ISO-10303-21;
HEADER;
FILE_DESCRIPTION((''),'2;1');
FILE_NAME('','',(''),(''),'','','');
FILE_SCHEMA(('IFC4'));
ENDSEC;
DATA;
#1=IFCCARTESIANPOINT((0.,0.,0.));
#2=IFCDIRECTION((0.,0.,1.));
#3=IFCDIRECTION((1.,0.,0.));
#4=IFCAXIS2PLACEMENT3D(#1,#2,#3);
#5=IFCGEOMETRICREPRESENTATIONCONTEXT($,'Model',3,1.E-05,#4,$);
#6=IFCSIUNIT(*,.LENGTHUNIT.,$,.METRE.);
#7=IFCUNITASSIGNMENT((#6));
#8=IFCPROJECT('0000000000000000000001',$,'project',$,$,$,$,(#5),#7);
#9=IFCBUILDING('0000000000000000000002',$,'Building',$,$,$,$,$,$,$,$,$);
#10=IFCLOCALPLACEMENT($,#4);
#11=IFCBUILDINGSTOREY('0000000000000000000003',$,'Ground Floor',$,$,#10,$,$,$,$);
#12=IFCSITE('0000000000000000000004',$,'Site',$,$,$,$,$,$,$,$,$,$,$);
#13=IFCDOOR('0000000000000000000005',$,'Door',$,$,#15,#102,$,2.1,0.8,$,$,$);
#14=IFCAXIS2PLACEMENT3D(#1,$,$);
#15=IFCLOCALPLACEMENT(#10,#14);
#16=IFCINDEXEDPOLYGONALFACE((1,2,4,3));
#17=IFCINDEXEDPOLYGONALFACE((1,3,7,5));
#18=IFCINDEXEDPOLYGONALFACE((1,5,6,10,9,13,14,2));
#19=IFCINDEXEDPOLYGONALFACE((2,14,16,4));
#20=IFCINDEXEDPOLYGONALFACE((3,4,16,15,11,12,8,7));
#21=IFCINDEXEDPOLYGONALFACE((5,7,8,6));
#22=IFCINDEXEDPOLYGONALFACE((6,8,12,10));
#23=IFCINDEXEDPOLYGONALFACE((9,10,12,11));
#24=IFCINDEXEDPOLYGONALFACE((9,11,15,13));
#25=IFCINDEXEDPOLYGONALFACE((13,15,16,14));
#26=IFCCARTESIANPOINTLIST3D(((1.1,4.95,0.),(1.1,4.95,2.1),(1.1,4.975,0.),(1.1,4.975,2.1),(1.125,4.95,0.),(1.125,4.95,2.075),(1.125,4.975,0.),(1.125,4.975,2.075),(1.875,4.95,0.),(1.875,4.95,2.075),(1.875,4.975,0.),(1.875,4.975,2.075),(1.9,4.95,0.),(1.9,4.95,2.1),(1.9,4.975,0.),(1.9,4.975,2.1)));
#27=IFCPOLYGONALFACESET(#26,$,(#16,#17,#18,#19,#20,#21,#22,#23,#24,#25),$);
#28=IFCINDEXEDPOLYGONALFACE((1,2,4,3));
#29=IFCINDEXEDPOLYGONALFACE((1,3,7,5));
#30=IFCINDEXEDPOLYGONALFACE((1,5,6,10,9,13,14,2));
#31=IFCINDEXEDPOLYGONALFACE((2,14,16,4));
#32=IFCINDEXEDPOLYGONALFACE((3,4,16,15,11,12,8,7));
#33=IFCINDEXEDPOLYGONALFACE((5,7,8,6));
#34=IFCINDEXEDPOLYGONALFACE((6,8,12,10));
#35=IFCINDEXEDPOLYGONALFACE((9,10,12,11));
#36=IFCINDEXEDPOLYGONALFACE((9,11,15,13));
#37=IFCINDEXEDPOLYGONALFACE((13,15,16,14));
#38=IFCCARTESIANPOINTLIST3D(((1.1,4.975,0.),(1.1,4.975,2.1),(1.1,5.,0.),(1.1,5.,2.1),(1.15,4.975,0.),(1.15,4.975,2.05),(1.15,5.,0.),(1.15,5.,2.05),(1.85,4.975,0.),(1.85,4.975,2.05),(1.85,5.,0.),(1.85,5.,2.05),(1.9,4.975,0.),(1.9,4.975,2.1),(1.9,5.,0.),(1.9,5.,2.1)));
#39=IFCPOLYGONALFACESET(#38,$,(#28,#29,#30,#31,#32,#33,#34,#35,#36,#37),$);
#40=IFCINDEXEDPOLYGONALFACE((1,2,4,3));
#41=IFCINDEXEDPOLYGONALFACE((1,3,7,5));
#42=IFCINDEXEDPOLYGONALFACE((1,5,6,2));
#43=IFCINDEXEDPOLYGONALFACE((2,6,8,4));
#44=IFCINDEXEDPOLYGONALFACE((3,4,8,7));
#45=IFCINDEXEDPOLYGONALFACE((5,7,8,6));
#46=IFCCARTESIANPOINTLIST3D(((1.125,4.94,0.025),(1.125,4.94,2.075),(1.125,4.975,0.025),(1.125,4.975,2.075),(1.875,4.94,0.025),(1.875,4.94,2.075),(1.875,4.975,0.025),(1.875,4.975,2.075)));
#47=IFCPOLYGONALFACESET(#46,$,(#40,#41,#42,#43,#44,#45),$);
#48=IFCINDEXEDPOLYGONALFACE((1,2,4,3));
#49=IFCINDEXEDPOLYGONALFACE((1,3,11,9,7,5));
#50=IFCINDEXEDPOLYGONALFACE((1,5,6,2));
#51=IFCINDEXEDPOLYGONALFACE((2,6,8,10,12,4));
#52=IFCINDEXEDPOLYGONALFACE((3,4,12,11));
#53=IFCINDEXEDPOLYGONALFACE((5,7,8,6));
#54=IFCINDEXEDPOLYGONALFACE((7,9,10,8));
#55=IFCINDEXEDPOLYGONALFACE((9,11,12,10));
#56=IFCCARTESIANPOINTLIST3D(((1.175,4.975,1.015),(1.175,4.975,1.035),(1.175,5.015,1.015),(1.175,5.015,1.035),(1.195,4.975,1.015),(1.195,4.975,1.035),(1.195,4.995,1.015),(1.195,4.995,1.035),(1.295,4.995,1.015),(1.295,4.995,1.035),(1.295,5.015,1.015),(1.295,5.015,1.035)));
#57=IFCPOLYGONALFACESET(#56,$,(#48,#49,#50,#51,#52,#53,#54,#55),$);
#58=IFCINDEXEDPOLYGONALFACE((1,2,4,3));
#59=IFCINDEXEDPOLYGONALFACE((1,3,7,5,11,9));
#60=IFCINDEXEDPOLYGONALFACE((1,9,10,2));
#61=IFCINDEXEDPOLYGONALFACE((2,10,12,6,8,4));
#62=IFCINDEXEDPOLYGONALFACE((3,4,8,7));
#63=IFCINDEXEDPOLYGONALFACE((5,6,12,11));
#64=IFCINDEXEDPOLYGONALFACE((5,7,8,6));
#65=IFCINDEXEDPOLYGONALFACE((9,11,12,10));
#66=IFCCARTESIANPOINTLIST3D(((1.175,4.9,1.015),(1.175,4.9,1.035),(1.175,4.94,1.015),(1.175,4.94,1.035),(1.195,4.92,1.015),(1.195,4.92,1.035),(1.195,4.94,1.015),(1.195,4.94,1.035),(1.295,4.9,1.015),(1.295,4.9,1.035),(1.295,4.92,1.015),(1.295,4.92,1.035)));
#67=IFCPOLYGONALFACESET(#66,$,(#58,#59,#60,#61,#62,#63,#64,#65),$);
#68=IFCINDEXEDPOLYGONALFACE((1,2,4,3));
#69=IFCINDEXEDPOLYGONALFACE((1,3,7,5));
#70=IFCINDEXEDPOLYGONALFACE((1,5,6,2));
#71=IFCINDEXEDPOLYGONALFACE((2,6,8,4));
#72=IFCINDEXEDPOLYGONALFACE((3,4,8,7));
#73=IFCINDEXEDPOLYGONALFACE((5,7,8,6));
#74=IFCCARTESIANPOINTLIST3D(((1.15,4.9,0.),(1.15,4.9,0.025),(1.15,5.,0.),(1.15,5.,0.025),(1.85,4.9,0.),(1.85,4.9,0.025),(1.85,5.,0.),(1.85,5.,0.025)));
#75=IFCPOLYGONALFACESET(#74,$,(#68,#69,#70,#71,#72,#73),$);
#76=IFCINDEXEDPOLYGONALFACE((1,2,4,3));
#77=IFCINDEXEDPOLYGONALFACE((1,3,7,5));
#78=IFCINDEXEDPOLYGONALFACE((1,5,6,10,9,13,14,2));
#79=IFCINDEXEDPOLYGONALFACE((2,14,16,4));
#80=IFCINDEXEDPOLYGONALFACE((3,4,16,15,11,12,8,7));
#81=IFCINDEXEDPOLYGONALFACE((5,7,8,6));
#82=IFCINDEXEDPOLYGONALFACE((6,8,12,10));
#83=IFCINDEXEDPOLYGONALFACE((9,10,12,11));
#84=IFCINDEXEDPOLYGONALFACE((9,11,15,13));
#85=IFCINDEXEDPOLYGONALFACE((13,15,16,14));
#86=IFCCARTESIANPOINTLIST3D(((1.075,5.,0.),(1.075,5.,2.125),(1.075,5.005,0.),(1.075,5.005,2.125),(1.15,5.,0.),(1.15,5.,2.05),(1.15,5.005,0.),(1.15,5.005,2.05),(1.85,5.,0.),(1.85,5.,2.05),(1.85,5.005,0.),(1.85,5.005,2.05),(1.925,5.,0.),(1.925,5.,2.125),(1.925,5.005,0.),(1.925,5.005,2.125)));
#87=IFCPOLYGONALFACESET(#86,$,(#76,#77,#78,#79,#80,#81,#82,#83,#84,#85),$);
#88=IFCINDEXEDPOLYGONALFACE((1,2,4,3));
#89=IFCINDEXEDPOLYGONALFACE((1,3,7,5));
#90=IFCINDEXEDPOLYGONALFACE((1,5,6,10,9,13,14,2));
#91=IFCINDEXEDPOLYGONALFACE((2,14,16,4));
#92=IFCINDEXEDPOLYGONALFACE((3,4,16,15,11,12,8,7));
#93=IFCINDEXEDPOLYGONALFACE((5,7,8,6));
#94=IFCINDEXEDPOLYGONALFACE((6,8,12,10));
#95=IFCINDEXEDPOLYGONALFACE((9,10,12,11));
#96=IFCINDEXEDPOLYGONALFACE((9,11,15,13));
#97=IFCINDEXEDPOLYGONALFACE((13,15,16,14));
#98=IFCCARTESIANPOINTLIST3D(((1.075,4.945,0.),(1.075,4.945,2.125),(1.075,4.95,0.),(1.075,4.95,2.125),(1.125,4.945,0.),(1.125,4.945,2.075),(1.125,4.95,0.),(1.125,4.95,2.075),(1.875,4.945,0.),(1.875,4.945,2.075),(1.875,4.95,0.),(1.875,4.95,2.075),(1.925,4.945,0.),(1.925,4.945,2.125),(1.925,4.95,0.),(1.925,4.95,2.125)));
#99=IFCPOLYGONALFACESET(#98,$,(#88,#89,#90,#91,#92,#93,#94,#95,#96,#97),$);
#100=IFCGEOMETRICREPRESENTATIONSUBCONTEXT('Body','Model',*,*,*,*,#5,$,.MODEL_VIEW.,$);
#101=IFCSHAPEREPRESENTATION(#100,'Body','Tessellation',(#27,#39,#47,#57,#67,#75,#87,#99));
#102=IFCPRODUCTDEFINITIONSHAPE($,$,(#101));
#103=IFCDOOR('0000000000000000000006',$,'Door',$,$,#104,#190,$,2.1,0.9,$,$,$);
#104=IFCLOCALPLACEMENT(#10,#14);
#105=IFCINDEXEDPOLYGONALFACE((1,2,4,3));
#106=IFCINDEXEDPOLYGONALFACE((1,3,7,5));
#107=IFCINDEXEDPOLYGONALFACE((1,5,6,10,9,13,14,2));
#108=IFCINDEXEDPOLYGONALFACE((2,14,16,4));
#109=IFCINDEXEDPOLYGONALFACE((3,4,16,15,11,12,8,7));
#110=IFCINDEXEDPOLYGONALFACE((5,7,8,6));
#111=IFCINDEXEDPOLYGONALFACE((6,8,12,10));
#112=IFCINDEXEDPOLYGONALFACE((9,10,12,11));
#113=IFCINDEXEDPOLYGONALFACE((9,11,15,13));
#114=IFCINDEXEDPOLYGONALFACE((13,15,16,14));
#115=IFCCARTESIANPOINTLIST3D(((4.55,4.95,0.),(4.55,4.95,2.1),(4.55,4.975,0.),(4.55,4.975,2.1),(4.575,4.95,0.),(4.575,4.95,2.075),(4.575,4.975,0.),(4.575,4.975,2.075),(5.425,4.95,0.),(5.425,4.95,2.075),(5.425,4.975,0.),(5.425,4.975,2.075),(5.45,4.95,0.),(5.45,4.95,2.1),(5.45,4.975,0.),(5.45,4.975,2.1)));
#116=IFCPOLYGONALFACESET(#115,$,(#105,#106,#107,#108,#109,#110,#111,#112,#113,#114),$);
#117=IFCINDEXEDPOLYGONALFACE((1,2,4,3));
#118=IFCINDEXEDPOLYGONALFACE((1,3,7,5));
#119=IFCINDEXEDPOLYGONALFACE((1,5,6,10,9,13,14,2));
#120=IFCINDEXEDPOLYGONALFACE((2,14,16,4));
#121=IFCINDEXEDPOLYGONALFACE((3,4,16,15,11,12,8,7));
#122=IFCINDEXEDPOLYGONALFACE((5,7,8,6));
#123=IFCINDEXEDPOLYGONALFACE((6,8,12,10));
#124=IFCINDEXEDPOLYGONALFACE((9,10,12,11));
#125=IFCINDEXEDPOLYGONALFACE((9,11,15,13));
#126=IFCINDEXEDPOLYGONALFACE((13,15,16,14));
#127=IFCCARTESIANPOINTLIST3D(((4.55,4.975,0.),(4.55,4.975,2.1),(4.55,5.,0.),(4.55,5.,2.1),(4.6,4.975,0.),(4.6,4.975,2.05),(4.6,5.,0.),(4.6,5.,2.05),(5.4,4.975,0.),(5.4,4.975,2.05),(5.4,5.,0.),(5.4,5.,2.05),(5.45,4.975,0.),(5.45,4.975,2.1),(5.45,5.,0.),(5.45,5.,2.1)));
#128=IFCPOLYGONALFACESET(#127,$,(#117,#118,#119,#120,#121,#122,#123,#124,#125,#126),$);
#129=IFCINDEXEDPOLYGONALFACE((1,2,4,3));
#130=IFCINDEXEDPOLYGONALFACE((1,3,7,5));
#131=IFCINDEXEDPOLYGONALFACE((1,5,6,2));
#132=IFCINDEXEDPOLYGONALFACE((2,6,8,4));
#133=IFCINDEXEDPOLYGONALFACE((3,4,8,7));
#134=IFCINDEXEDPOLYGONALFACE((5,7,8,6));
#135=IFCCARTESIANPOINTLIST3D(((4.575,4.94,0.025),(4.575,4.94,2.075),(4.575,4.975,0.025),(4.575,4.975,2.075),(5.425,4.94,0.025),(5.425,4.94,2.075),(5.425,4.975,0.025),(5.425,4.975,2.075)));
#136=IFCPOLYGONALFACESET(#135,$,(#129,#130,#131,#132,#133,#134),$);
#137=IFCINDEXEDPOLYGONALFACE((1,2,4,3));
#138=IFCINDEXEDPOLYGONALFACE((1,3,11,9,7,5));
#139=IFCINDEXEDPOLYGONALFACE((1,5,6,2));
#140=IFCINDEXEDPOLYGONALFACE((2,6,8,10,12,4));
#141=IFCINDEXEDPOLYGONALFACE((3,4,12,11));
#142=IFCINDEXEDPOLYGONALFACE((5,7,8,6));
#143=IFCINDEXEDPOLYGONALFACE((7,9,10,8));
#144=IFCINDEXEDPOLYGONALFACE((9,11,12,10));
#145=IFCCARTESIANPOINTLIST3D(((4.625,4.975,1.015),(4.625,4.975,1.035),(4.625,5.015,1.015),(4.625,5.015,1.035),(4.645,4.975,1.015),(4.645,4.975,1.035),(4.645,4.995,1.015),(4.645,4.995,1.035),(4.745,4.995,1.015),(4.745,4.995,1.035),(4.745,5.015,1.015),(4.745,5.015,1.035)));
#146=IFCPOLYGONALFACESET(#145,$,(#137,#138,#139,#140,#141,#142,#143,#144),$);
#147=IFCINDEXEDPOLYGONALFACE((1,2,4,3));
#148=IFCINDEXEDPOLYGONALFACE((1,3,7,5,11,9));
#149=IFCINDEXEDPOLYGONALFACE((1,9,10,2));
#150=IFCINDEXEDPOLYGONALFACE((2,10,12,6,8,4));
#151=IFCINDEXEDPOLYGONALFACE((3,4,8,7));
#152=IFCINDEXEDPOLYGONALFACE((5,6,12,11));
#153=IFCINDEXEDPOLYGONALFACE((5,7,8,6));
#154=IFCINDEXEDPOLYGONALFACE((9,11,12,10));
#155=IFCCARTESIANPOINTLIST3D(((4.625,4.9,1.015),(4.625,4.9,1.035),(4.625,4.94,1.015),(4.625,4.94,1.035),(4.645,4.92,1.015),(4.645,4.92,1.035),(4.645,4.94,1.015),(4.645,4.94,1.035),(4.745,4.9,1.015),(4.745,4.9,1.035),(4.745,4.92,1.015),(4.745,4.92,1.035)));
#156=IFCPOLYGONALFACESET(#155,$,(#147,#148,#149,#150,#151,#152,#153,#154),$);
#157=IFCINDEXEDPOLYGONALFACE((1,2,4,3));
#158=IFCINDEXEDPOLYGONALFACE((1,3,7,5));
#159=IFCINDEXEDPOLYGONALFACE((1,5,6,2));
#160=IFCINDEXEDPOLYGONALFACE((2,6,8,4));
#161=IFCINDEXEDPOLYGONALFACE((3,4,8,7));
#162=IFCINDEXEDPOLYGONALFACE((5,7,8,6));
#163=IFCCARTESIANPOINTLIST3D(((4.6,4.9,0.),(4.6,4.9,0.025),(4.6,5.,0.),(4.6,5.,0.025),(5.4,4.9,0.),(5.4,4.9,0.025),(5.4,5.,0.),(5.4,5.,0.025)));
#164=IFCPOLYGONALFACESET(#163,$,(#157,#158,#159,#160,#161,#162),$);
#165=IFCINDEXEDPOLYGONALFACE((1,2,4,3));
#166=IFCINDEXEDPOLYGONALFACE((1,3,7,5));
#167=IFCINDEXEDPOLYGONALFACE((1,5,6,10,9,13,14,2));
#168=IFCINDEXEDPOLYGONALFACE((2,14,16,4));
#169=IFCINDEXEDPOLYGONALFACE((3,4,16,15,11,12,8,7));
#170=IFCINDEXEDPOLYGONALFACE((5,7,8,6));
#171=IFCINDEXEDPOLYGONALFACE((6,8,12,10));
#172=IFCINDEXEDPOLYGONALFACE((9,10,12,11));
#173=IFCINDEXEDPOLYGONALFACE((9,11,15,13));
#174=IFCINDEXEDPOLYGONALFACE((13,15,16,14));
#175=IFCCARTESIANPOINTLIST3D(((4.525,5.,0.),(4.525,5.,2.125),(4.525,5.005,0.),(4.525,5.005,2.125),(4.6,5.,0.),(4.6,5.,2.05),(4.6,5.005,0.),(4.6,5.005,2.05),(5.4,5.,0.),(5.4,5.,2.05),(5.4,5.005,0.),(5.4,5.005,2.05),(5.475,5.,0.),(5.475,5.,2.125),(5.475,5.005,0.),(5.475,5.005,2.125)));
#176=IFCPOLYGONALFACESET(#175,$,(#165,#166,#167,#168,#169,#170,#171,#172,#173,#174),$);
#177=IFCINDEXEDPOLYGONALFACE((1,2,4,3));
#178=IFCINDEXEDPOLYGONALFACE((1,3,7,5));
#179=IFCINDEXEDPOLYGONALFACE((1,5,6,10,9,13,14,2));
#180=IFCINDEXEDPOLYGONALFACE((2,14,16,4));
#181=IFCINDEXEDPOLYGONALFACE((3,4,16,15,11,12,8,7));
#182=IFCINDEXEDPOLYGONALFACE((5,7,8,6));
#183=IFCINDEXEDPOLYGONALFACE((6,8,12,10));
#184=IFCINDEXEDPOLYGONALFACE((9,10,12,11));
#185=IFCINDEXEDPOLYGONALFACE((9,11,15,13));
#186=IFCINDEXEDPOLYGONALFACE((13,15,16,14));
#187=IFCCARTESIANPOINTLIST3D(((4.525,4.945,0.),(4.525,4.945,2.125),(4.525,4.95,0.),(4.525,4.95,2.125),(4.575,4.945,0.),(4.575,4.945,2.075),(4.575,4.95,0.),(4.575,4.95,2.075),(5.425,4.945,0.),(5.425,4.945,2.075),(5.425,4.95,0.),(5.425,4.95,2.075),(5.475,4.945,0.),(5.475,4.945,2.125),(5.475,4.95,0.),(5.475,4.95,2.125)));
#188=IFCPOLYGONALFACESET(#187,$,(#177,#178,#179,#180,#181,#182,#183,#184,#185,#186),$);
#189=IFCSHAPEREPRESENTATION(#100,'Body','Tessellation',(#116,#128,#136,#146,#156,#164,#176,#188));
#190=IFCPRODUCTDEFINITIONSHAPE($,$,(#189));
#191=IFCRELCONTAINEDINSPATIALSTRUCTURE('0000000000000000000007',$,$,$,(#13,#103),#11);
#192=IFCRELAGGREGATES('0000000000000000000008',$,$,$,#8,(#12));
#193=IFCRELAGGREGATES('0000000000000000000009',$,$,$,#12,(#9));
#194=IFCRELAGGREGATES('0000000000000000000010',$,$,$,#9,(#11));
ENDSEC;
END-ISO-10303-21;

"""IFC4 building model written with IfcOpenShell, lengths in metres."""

from ifc_helpers import new_model, si_unit, frame, origin_with_axes, place, context, subcontext, project, spatial, line, indexed_curve, outline, extrude, element, save


model = new_model("IFC4")

# Units and contexts
model_context = context("Model", 3, precision=1e-05, world=origin_with_axes())
body_context = subcontext(model_context, "Body", "Model", "MODEL_VIEW")
ifc_project = project(units=[si_unit("LENGTHUNIT", "METRE")], contexts=[model_context])

# Site, building, storey
site = spatial("IfcSite", under=ifc_project, Name="Site")
building = spatial("IfcBuilding", under=site, Name="Building")
storey_placement = place(None, origin_with_axes())
storey = spatial("IfcBuildingStorey", under=building, at=storey_placement, Name="Ground Floor")

# Doors
door_1_placement = place(storey_placement, frame((1.9, 5.0, 0.0), z_axis=(0.0, 0.0, 1.0), x_axis=(-1.0, 0.0, 0.0)))
element("IfcDoor", 1, at=door_1_placement, inside=storey, Name="Door", OverallHeight=2.1, OverallWidth=0.8, context=body_context, shape_type="SweptSolid", body=[
    extrude(outline(indexed_curve([(0.0, 0.0), (0.0, 2.1), (0.8, 2.1), (0.8, 0.0), (0.775, 0.0), (0.775, 2.075), (0.025, 2.075), (0.025, 0.0)], segments=[line(1, 2, 3, 4, 5, 6, 7, 8, 1)])), frame((0.0, 0.025, 0.0), z_axis=(0.0, -1.0, 0.0), x_axis=(1.0, 0.0, 0.0)), (0.0, 0.0, -1.0), 0.025),
    extrude(outline(indexed_curve([(0.0, 0.0), (0.0, 2.1), (0.8, 2.1), (0.8, 0.0), (0.75, 0.0), (0.75, 2.05), (0.05, 2.05), (0.05, 0.0)], segments=[line(1, 2, 3, 4, 5, 6, 7, 8, 1)])), frame((0.0, 0.0, 0.0), z_axis=(0.0, -1.0, 0.0), x_axis=(1.0, 0.0, 0.0)), (0.0, 0.0, -1.0), 0.025),
    extrude(outline(indexed_curve([(0.0, 0.0), (0.75, 0.0), (0.75, 0.035), (0.0, 0.035)], segments=[line(1, 2, 3, 4, 1)])), frame((0.025, 0.025, 0.025), z_axis=(0.0, 0.0, 1.0), x_axis=(1.0, 0.0, 0.0)), (0.0, 0.0, 1.0), 2.05),
    extrude(outline(indexed_curve([(0.0, 0.0), (0.0, -0.04), (-0.12, -0.04), (-0.12, -0.02), (-0.02, -0.02), (-0.02, 0.0)], segments=[line(1, 2, 3, 4, 5, 6, 1)])), frame((0.725, 0.025, 1.015), z_axis=(0.0, 0.0, 1.0), x_axis=(1.0, 0.0, 0.0)), (0.0, 0.0, 1.0), 0.02),
    extrude(outline(indexed_curve([(0.0, 0.0), (0.0, 0.04), (-0.12, 0.04), (-0.12, 0.02), (-0.02, 0.02), (-0.02, 0.0)], segments=[line(1, 2, 3, 4, 5, 6, 1)])), frame((0.725, 0.06, 1.015), z_axis=(0.0, 0.0, 1.0), x_axis=(1.0, 0.0, 0.0)), (0.0, 0.0, 1.0), 0.02),
    extrude(outline(indexed_curve([(0.0, 0.0), (0.7, 0.0), (0.7, 0.1), (0.0, 0.1)], segments=[line(1, 2, 3, 4, 1)])), frame((0.05, 0.0, 0.0), z_axis=(0.0, 0.0, 1.0), x_axis=(1.0, 0.0, 0.0)), (0.0, 0.0, 1.0), 0.025),
    extrude(outline(indexed_curve([(0.0, 0.0), (0.0, 2.125), (0.85, 2.125), (0.85, 0.0), (0.775, 0.0), (0.775, 2.05), (0.075, 2.05), (0.075, 0.0)], segments=[line(1, 2, 3, 4, 5, 6, 7, 8, 1)])), frame((-0.025, -0.005, 0.0), z_axis=(0.0, -1.0, 0.0), x_axis=(1.0, 0.0, 0.0)), (0.0, 0.0, -1.0), 0.005),
    extrude(outline(indexed_curve([(0.0, 0.0), (0.0, 2.125), (0.85, 2.125), (0.85, 0.0), (0.8, 0.0), (0.8, 2.075), (0.05, 2.075), (0.05, 0.0)], segments=[line(1, 2, 3, 4, 5, 6, 7, 8, 1)])), frame((-0.025, 0.05, 0.0), z_axis=(0.0, -1.0, 0.0), x_axis=(1.0, 0.0, 0.0)), (0.0, 0.0, -1.0), 0.005),
])
door_2_placement = place(storey_placement, frame((5.45, 5.0, 0.0), z_axis=(0.0, 0.0, 1.0), x_axis=(-1.0, 0.0, 0.0)))
element("IfcDoor", 2, at=door_2_placement, inside=storey, Name="Door", OverallHeight=2.1, OverallWidth=0.9, context=body_context, shape_type="SweptSolid", body=[
    extrude(outline(indexed_curve([(0.0, 0.0), (0.0, 2.1), (0.9, 2.1), (0.9, 0.0), (0.875, 0.0), (0.875, 2.075), (0.025, 2.075), (0.025, 0.0)], segments=[line(1, 2, 3, 4, 5, 6, 7, 8, 1)])), frame((0.0, 0.025, 0.0), z_axis=(0.0, -1.0, 0.0), x_axis=(1.0, 0.0, 0.0)), (0.0, 0.0, -1.0), 0.025),
    extrude(outline(indexed_curve([(0.0, 0.0), (0.0, 2.1), (0.9, 2.1), (0.9, 0.0), (0.85, 0.0), (0.85, 2.05), (0.05, 2.05), (0.05, 0.0)], segments=[line(1, 2, 3, 4, 5, 6, 7, 8, 1)])), frame((0.0, 0.0, 0.0), z_axis=(0.0, -1.0, 0.0), x_axis=(1.0, 0.0, 0.0)), (0.0, 0.0, -1.0), 0.025),
    extrude(outline(indexed_curve([(0.0, 0.0), (0.85, 0.0), (0.85, 0.035), (0.0, 0.035)], segments=[line(1, 2, 3, 4, 1)])), frame((0.025, 0.025, 0.025), z_axis=(0.0, 0.0, 1.0), x_axis=(1.0, 0.0, 0.0)), (0.0, 0.0, 1.0), 2.05),
    extrude(outline(indexed_curve([(0.0, 0.0), (0.0, -0.04), (-0.12, -0.04), (-0.12, -0.02), (-0.02, -0.02), (-0.02, 0.0)], segments=[line(1, 2, 3, 4, 5, 6, 1)])), frame((0.825, 0.025, 1.015), z_axis=(0.0, 0.0, 1.0), x_axis=(1.0, 0.0, 0.0)), (0.0, 0.0, 1.0), 0.02),
    extrude(outline(indexed_curve([(0.0, 0.0), (0.0, 0.04), (-0.12, 0.04), (-0.12, 0.02), (-0.02, 0.02), (-0.02, 0.0)], segments=[line(1, 2, 3, 4, 5, 6, 1)])), frame((0.825, 0.06, 1.015), z_axis=(0.0, 0.0, 1.0), x_axis=(1.0, 0.0, 0.0)), (0.0, 0.0, 1.0), 0.02),
    extrude(outline(indexed_curve([(0.0, 0.0), (0.8, 0.0), (0.8, 0.1), (0.0, 0.1)], segments=[line(1, 2, 3, 4, 1)])), frame((0.05, 0.0, 0.0), z_axis=(0.0, 0.0, 1.0), x_axis=(1.0, 0.0, 0.0)), (0.0, 0.0, 1.0), 0.025),
    extrude(outline(indexed_curve([(0.0, 0.0), (0.0, 2.125), (0.95, 2.125), (0.95, 0.0), (0.875, 0.0), (0.875, 2.05), (0.075, 2.05), (0.075, 0.0)], segments=[line(1, 2, 3, 4, 5, 6, 7, 8, 1)])), frame((-0.025, -0.005, 0.0), z_axis=(0.0, -1.0, 0.0), x_axis=(1.0, 0.0, 0.0)), (0.0, 0.0, -1.0), 0.005),
    extrude(outline(indexed_curve([(0.0, 0.0), (0.0, 2.125), (0.95, 2.125), (0.95, 0.0), (0.9, 0.0), (0.9, 2.075), (0.05, 2.075), (0.05, 0.0)], segments=[line(1, 2, 3, 4, 5, 6, 7, 8, 1)])), frame((-0.025, 0.05, 0.0), z_axis=(0.0, -1.0, 0.0), x_axis=(1.0, 0.0, 0.0)), (0.0, 0.0, -1.0), 0.005),
])

save(model, "model.ifc")
